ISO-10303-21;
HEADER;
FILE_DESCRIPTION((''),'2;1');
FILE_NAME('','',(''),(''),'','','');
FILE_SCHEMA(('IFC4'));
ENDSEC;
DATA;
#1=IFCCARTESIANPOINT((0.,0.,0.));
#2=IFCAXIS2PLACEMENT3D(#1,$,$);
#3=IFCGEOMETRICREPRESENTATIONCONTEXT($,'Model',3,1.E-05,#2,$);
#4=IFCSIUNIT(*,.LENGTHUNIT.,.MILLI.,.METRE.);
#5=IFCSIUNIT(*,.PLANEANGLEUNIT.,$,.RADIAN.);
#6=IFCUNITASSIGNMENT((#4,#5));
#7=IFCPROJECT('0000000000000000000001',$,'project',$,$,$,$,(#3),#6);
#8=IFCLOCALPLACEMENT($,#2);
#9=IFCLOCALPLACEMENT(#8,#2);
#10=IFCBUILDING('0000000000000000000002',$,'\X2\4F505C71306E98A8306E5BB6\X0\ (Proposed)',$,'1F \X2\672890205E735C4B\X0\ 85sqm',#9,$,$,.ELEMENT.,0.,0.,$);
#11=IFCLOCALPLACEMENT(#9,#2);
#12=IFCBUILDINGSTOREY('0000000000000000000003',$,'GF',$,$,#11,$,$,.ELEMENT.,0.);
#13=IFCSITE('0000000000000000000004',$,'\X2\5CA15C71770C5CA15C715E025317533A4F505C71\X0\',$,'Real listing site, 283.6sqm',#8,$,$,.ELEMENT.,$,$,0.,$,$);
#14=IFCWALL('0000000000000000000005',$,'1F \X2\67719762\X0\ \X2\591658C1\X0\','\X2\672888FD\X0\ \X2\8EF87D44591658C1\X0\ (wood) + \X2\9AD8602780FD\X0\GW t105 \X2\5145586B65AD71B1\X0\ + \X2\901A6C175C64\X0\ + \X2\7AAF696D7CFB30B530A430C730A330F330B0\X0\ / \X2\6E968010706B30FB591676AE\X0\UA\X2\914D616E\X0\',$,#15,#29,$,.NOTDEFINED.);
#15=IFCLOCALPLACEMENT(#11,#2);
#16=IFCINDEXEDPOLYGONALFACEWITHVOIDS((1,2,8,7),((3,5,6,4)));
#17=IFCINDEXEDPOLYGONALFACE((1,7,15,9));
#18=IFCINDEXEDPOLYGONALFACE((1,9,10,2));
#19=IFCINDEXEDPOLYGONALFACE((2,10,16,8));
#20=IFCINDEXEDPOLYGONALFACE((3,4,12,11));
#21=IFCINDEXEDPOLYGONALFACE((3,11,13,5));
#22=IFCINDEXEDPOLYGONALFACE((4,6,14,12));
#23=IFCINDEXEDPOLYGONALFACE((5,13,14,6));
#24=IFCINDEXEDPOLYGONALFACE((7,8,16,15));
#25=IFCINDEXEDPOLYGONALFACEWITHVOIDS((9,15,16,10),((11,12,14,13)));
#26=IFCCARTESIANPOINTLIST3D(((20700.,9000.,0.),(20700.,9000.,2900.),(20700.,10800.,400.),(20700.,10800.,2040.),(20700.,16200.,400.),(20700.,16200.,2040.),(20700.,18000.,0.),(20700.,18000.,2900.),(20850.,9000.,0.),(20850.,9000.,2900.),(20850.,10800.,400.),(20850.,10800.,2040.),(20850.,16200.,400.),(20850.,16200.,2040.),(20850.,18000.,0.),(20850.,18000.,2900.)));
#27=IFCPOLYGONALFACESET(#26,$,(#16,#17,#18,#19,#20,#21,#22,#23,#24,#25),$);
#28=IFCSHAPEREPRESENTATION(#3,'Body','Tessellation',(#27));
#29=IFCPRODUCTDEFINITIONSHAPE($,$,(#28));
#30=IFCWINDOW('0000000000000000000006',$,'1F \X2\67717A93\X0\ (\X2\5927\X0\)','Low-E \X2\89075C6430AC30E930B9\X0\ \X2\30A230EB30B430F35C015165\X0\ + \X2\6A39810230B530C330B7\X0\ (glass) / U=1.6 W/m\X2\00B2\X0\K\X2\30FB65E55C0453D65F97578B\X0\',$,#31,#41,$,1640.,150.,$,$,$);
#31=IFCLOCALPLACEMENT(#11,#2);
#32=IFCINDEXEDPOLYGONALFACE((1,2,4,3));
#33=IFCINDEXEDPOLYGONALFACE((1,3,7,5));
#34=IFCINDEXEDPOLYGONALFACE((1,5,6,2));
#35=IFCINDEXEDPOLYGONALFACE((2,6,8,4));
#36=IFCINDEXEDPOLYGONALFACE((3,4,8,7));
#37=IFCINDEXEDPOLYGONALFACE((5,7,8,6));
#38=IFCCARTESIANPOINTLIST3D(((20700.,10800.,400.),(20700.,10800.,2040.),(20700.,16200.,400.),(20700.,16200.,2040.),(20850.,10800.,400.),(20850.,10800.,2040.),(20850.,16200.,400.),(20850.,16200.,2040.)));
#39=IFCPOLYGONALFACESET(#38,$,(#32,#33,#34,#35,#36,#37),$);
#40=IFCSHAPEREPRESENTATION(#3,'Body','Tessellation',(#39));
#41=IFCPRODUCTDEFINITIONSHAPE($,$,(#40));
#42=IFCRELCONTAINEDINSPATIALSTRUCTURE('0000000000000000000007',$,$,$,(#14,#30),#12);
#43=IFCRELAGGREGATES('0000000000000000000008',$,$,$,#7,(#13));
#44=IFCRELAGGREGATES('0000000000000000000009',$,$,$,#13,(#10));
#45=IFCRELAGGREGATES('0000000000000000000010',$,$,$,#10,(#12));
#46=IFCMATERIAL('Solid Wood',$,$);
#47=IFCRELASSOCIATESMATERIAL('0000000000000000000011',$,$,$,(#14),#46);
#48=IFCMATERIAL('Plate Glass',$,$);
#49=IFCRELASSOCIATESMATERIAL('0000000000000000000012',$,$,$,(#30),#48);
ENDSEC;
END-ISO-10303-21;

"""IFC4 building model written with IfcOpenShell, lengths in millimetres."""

from ifc_helpers import new_model, si_unit, frame, frame_2d, origin, place, context, project, spatial, rectangle, extrude, material, element, fill, save


model = new_model("IFC4")

# Units and contexts
model_context = context("Model", 3, precision=1e-05, world=origin())
ifc_project = project(units=[si_unit("LENGTHUNIT", "METRE", prefix="MILLI"), si_unit("PLANEANGLEUNIT", "RADIAN")], contexts=[model_context])

# Site, building, storey
site_placement = place(None, origin())
site = spatial("IfcSite", under=ifc_project, at=site_placement, Name="岡山県岡山市北区佐山", ObjectType="Real listing site, 283.6sqm", CompositionType="ELEMENT", RefElevation=0.0)
building_placement = place(site_placement, origin())
building = spatial("IfcBuilding", under=site, at=building_placement, Name="佐山の風の家 (Proposed)", ObjectType="1F 木造平屋 85sqm", CompositionType="ELEMENT", ElevationOfRefHeight=0.0, ElevationOfTerrain=0.0)
storey_placement = place(building_placement, origin())
storey = spatial("IfcBuildingStorey", under=building, at=storey_placement, Name="GF", CompositionType="ELEMENT", Elevation=0.0)

# Shared definitions
ifc_material_1 = material(Name="Solid Wood")

# Wall, opening, window
wall_1_placement = place(storey_placement, frame((10350.0, 4500.0, 0.0)))
wall_1 = element("IfcWall", 1, at=wall_1_placement, inside=storey, material=ifc_material_1, Name="1F 東面 外壁", Description="木製 軸組外壁 (wood) + 高性能GW t105 充填断熱 + 通気層 + 窯業系サイディング / 準耐火・外皮UA配慮", PredefinedType="NOTDEFINED", context=model_context, shape_type="SweptSolid", body=[
    extrude(rectangle(XDim=150.0, YDim=9000.0, at=frame_2d((75.0, 4500.0))), frame((10350.0, 4500.0, 0.0)), (0.0, 0.0, 1.0), 2900.0),
])
opening_1_placement = place(storey_placement, frame((10350.0, 5400.0, 200.0)))
opening_1 = element("IfcOpeningElement", 2, at=opening_1_placement, cuts=wall_1, PredefinedType="NOTDEFINED", context=model_context, shape_type="SweptSolid", body=[
    extrude(rectangle(XDim=150.0, YDim=5400.0, at=frame_2d((75.0, 2700.0))), frame((10350.0, 5400.0, 200.0)), (0.0, 0.0, 1.0), 1640.0),
])
ifc_material_2 = material(Name="Plate Glass")
window_1_placement = place(storey_placement, frame((10350.0, 5400.0, 200.0)))
window_1 = element("IfcWindow", 3, at=window_1_placement, inside=storey, material=ifc_material_2, Name="1F 東窓 (大)", Description="Low-E 複層ガラス アルゴン封入 + 樹脂サッシ (glass) / U=1.6 W/m²K・日射取得型", OverallHeight=1640.0, OverallWidth=150.0, context=model_context, shape_type="SweptSolid", body=[
    extrude(rectangle(XDim=150.0, YDim=5400.0, at=frame_2d((75.0, 2700.0))), frame((10350.0, 5400.0, 200.0)), (0.0, 0.0, 1.0), 1640.0),
])
fill(opening_1, window_1)

save(model, "model.ifc")
